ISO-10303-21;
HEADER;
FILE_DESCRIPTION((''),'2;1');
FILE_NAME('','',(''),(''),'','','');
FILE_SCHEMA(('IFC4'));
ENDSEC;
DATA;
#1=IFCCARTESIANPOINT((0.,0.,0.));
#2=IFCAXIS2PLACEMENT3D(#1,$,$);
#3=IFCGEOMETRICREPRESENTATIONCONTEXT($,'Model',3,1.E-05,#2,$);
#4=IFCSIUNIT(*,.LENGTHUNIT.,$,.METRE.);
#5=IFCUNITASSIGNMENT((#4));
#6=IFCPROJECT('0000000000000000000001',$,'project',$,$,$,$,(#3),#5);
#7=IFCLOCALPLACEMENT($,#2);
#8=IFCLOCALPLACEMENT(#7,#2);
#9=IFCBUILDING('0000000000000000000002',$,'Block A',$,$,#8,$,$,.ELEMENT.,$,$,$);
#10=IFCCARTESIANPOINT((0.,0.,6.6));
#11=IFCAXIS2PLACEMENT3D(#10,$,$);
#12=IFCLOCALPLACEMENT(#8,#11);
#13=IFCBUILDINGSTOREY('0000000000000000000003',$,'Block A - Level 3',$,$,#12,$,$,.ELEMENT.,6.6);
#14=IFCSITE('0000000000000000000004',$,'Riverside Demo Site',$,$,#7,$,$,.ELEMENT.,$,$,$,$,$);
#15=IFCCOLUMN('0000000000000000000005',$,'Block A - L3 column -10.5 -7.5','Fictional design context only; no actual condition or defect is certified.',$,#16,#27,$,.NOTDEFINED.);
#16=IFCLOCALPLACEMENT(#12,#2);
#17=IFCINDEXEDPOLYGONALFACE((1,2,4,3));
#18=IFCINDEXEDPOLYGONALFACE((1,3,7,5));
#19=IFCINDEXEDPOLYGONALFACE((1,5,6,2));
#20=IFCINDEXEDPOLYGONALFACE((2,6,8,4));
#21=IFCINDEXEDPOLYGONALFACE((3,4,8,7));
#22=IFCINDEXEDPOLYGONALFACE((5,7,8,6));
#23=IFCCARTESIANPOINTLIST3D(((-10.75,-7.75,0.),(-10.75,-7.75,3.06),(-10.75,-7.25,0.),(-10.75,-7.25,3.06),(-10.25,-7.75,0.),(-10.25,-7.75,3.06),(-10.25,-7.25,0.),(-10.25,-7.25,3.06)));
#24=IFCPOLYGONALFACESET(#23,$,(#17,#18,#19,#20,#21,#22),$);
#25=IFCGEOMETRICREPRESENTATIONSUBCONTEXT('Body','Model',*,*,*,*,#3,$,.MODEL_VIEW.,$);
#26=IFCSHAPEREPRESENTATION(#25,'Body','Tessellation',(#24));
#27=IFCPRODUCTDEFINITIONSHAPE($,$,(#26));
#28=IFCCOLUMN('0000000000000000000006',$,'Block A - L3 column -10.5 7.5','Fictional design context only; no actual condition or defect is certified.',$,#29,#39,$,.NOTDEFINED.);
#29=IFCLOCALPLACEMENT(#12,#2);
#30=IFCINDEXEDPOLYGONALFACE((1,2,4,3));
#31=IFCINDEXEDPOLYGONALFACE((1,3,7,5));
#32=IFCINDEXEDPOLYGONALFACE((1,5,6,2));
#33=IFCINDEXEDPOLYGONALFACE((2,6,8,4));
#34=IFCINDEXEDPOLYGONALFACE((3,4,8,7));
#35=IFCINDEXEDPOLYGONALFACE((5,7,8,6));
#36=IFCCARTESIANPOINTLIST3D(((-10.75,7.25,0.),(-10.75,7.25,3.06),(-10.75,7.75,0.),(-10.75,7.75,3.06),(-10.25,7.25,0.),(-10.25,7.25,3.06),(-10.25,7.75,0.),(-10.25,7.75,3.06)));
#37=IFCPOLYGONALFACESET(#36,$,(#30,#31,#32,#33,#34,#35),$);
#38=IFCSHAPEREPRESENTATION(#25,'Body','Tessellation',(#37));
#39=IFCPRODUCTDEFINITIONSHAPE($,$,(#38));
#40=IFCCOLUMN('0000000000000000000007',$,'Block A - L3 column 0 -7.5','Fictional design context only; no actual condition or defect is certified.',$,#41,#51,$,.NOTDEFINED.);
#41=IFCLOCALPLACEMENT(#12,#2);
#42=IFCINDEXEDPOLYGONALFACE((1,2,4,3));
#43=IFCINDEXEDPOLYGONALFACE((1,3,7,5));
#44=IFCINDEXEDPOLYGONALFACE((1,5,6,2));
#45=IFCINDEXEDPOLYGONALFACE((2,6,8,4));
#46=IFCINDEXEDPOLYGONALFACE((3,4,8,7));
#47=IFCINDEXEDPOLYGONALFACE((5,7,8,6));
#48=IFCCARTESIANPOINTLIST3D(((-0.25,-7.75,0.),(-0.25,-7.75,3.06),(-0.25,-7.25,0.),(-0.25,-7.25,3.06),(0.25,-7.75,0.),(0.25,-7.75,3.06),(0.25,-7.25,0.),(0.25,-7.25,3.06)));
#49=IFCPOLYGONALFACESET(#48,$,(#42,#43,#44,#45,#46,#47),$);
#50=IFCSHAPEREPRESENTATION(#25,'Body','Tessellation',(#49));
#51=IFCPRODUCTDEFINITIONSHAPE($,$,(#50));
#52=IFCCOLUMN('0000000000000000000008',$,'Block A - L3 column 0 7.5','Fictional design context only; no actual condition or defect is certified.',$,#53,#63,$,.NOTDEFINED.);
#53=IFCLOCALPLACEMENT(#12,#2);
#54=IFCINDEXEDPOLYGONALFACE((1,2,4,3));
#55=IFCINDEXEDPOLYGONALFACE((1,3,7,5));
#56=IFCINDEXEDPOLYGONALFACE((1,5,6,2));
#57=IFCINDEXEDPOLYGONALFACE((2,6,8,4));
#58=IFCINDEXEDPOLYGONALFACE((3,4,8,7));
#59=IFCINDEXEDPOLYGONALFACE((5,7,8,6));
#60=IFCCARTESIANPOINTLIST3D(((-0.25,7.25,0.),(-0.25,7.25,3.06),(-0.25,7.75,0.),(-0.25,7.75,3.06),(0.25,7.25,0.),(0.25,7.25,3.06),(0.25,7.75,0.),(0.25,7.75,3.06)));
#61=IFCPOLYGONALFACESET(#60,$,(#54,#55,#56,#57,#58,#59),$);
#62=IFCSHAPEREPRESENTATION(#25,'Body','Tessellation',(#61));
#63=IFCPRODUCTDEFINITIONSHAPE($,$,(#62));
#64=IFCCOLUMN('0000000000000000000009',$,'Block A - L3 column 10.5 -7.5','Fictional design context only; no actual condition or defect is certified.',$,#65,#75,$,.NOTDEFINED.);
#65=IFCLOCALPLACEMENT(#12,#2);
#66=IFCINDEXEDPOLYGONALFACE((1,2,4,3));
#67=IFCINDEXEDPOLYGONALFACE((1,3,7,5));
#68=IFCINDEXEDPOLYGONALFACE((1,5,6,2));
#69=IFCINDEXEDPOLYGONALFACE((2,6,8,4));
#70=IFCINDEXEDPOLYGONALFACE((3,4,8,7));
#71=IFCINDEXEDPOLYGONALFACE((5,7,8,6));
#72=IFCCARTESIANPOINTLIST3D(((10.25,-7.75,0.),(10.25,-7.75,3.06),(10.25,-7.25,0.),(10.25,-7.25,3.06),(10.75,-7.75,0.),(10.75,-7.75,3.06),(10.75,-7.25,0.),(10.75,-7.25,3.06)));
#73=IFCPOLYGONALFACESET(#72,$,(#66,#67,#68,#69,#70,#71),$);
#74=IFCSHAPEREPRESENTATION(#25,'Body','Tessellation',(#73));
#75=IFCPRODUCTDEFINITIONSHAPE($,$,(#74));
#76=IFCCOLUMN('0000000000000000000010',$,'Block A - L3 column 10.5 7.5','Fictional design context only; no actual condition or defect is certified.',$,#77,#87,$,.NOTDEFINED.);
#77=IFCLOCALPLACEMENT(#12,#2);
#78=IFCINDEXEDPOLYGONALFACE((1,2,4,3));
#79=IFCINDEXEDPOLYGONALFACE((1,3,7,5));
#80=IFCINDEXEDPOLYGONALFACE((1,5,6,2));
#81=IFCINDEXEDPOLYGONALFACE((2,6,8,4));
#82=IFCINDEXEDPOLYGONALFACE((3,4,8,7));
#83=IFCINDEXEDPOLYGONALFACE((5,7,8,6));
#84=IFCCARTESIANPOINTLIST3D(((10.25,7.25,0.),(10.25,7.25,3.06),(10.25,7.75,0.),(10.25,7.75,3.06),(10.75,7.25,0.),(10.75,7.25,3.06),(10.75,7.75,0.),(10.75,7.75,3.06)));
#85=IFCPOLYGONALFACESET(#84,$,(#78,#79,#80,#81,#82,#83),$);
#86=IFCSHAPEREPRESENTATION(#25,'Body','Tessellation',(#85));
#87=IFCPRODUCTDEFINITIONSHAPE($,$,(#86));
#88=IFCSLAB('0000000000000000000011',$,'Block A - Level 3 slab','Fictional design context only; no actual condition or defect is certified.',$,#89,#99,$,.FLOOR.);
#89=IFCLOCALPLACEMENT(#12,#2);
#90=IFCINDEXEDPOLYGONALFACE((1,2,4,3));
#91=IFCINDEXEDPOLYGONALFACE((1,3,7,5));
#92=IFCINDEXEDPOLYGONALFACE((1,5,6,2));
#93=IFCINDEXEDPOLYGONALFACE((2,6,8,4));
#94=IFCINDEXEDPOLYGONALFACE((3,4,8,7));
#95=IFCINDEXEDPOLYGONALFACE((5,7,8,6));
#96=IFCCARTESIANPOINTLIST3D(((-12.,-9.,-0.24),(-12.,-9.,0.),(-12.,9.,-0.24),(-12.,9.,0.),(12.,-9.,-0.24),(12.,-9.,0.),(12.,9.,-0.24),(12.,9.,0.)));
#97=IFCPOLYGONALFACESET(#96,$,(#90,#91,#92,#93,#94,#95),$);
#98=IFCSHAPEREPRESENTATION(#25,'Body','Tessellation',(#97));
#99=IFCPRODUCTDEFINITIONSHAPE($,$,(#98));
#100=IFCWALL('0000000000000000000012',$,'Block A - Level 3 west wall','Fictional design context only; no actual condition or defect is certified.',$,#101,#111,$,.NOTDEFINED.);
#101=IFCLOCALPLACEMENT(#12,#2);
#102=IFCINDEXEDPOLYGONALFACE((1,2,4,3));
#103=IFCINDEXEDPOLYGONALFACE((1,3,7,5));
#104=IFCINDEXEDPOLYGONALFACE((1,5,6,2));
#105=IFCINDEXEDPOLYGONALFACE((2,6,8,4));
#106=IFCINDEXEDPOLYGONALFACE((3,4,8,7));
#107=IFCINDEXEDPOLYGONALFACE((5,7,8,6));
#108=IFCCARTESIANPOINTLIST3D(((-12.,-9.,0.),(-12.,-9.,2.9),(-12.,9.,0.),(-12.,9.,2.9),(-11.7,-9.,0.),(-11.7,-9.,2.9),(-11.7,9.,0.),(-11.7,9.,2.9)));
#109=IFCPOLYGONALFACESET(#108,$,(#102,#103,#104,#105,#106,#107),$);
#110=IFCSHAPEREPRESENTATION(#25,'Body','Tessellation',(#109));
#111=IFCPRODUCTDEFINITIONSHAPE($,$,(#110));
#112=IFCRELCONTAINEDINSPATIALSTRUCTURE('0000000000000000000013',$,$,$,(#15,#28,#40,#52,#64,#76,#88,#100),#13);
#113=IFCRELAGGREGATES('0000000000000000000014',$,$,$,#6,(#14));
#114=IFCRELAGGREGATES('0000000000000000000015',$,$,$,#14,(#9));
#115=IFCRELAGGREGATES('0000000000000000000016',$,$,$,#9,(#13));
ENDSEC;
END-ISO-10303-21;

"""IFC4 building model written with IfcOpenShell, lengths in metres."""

from ifc_helpers import new_model, si_unit, frame, origin, origin_2d, place, context, subcontext, project, spatial, rectangle, extrude, element, save


model = new_model("IFC4")

# Units and contexts
model_context = context("Model", 3, precision=1e-05, world=origin())
body_context = subcontext(model_context, "Body", "Model", "MODEL_VIEW")
ifc_project = project(units=[si_unit("LENGTHUNIT", "METRE")], contexts=[model_context])

# Site, building, storey
site_placement = place(None, origin())
site = spatial("IfcSite", under=ifc_project, at=site_placement, Name="Riverside Demo Site", CompositionType="ELEMENT")
building_placement = place(site_placement, origin())
building = spatial("IfcBuilding", under=site, at=building_placement, Name="Block A", CompositionType="ELEMENT")
storey_placement = place(building_placement, frame((0.0, 0.0, 6.6)))
storey = spatial("IfcBuildingStorey", under=building, at=storey_placement, Name="Block A - Level 3", CompositionType="ELEMENT", Elevation=6.6)

# Columns
for number, where, name in (
    (1, (-10.5, -7.5, 0.0), "Block A - L3 column -10.5 -7.5"),
    (2, (-10.5, 7.5, 0.0), "Block A - L3 column -10.5 7.5"),
    (3, (0.0, -7.5, 0.0), "Block A - L3 column 0 -7.5"),
    (4, (0.0, 7.5, 0.0), "Block A - L3 column 0 7.5"),
    (5, (10.5, -7.5, 0.0), "Block A - L3 column 10.5 -7.5"),
    (6, (10.5, 7.5, 0.0), "Block A - L3 column 10.5 7.5"),
):
    element("IfcColumn", number, at=place(storey_placement, frame(where)), inside=storey, Name=name, Description="Fictional design context only; no actual condition or defect is certified.", PredefinedType="NOTDEFINED", context=body_context, shape_type="SweptSolid", body=[
        extrude(rectangle(XDim=0.5, YDim=0.5, at=origin_2d()), origin(), (0.0, 0.0, 1.0), 3.06),
    ])

# Slab
slab_placement = place(storey_placement, frame((0.0, 0.0, -0.24)))
element("IfcSlab", 7, at=slab_placement, inside=storey, Name="Block A - Level 3 slab", Description="Fictional design context only; no actual condition or defect is certified.", PredefinedType="FLOOR", context=body_context, shape_type="SweptSolid", body=[
    extrude(rectangle(XDim=24.0, YDim=18.0, at=origin_2d()), origin(), (0.0, 0.0, 1.0), 0.24),
])

# Wall
wall_placement = place(storey_placement, frame((-11.85, 0.0, 0.0)))
element("IfcWall", 8, at=wall_placement, inside=storey, Name="Block A - Level 3 west wall", Description="Fictional design context only; no actual condition or defect is certified.", PredefinedType="NOTDEFINED", context=body_context, shape_type="SweptSolid", body=[
    extrude(rectangle(XDim=0.3, YDim=18.0, at=origin_2d()), origin(), (0.0, 0.0, 1.0), 2.9),
])

save(model, "model.ifc")
